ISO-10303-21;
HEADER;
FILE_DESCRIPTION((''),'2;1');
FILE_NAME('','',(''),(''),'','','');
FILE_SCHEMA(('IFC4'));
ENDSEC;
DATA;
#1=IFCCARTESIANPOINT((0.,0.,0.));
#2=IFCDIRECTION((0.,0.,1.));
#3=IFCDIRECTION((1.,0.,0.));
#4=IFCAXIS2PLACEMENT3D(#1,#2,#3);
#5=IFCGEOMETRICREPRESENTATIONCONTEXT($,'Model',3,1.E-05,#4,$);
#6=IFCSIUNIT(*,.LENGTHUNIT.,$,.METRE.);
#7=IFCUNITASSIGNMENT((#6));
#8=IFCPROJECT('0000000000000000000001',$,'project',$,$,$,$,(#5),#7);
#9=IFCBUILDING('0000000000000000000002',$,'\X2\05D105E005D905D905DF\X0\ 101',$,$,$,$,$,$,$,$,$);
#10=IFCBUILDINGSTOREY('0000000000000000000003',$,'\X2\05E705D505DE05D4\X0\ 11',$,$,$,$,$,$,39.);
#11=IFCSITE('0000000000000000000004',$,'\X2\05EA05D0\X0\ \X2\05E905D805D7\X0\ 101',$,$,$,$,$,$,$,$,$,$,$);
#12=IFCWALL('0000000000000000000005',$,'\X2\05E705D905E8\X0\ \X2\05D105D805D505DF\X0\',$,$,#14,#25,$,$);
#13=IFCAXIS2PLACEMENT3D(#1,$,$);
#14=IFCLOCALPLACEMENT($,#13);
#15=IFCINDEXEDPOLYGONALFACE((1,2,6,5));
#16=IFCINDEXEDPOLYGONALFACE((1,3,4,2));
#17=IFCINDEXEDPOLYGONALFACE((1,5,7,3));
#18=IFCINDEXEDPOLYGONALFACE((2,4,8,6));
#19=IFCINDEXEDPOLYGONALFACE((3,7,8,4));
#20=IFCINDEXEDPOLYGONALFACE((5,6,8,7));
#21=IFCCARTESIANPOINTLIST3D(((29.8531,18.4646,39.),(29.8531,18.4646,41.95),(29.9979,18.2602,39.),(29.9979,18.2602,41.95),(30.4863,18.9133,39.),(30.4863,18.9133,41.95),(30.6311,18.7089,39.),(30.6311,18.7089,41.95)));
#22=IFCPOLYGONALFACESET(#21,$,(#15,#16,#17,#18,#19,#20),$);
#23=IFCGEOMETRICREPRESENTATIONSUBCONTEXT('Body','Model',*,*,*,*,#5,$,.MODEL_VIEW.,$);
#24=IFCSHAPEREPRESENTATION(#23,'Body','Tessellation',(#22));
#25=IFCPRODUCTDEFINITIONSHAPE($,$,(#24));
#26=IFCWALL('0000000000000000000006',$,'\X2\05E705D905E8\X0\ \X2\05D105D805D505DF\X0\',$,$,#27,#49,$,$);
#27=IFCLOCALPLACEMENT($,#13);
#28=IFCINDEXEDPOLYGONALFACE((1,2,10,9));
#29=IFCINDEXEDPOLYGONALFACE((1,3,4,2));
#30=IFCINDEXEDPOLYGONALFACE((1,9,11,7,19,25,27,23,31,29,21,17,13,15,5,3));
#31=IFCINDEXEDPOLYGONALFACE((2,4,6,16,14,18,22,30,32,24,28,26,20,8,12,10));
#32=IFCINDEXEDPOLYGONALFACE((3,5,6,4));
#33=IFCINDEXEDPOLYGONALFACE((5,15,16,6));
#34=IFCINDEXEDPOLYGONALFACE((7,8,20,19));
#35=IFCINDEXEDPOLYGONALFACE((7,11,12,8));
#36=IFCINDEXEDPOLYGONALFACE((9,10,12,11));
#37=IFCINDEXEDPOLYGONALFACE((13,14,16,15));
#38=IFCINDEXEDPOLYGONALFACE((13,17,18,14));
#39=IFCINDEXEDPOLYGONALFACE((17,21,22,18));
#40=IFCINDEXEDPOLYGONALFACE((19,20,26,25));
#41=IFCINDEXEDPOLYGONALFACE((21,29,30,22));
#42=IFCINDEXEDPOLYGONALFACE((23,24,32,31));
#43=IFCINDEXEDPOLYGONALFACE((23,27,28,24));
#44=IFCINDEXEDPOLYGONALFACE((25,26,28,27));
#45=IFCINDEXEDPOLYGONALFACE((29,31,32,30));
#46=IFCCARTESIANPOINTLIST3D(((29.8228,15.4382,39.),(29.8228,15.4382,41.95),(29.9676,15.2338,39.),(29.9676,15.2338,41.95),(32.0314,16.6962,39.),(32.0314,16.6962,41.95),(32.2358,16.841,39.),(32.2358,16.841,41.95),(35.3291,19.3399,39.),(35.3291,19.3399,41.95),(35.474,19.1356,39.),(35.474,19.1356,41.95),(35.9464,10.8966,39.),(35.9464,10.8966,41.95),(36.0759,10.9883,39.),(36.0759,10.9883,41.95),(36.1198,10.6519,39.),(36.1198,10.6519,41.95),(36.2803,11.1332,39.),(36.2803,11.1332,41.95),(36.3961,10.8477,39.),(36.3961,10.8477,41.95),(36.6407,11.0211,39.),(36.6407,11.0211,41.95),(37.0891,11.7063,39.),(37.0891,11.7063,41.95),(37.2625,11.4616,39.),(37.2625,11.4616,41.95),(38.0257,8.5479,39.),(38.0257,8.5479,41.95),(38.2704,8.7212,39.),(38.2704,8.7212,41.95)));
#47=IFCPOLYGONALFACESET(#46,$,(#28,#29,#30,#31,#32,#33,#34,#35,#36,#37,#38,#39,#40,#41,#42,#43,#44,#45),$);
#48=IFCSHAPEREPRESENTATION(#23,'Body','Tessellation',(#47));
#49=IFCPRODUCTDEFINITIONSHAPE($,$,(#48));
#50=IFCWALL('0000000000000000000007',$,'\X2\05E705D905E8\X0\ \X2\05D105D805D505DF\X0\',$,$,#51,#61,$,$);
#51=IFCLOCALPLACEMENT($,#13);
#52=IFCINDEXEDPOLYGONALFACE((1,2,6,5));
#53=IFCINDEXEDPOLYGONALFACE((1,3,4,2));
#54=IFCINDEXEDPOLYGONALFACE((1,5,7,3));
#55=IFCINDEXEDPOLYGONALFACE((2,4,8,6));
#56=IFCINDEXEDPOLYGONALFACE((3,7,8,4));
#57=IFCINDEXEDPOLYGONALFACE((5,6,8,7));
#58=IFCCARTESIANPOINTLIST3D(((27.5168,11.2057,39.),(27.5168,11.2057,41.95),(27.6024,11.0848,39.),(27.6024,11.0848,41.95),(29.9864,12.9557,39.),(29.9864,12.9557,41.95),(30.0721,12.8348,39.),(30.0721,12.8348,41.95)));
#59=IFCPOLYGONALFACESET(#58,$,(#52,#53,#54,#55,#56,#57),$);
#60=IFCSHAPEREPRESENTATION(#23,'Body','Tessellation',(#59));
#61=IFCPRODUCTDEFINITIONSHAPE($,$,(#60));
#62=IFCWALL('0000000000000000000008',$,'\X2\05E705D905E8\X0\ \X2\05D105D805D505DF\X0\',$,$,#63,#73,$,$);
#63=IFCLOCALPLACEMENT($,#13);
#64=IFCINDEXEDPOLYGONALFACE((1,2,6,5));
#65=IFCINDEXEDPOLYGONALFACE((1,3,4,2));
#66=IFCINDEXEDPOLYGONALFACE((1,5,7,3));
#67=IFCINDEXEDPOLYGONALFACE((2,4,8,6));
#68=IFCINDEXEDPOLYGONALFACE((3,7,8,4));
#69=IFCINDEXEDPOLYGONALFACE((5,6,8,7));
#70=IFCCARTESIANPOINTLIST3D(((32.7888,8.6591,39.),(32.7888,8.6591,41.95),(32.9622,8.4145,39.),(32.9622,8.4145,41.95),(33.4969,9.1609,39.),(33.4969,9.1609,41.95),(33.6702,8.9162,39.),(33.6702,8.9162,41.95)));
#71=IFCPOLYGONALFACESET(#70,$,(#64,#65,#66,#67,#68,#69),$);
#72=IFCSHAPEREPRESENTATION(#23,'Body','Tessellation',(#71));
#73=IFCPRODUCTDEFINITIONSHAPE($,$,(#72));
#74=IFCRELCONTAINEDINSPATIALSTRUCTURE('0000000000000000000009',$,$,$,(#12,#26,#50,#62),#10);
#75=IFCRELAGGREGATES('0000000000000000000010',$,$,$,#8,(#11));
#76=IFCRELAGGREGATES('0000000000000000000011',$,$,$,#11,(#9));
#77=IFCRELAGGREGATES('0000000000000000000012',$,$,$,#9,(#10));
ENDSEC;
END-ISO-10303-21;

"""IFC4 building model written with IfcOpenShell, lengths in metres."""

from ifc_helpers import new_model, si_unit, frame, origin_with_axes, context, subcontext, project, spatial, polyline, outline, extrude, element, save


model = new_model("IFC4")

# Units and contexts
model_context = context("Model", 3, precision=1e-05, world=origin_with_axes())
body_context = subcontext(model_context, "Body", "Model", "MODEL_VIEW")
ifc_project = project(units=[si_unit("LENGTHUNIT", "METRE")], contexts=[model_context])

# Site, building, storey
site = spatial("IfcSite", under=ifc_project, Name="תא שטח 101")
building = spatial("IfcBuilding", under=site, Name="בניין 101")
storey = spatial("IfcBuildingStorey", under=building, Name="קומה 11", Elevation=39.0)

# Walls
element("IfcWall", 1, inside=storey, Name="קיר בטון", context=body_context, shape_type="SweptSolid", body=[
    extrude(outline(polyline([(29.9979, 18.2602), (30.6311, 18.7089), (30.4863, 18.9133), (29.8531, 18.4646), (29.9979, 18.2602)])), frame((0.0, 0.0, 39.0)), (0.0, 0.0, 1.0), 2.95),
])
element("IfcWall", 2, inside=storey, Name="קיר בטון", context=body_context, shape_type="SweptSolid", body=[
    extrude(outline(polyline([(29.8228, 15.4382), (29.9676, 15.2338), (32.0314, 16.6962), (36.0759, 10.9883), (35.9464, 10.8966), (36.1198, 10.6519), (36.3961, 10.8477), (38.0257, 8.5479), (38.2704, 8.7212), (36.6407, 11.0211), (37.2625, 11.4616), (37.0891, 11.7063), (36.2803, 11.1332), (32.2358, 16.841), (35.474, 19.1356), (35.3291, 19.3399), (29.8228, 15.4382)])), frame((0.0, 0.0, 39.0)), (0.0, 0.0, 1.0), 2.95),
])
element("IfcWall", 3, inside=storey, Name="קיר בטון", context=body_context, shape_type="SweptSolid", body=[
    extrude(outline(polyline([(30.0721, 12.8348), (29.9864, 12.9557), (27.5168, 11.2057), (27.6024, 11.0848), (30.0721, 12.8348)])), frame((0.0, 0.0, 39.0)), (0.0, 0.0, 1.0), 2.95),
])
element("IfcWall", 4, inside=storey, Name="קיר בטון", context=body_context, shape_type="SweptSolid", body=[
    extrude(outline(polyline([(33.4969, 9.1609), (32.7888, 8.6591), (32.9622, 8.4145), (33.6702, 8.9162), (33.4969, 9.1609)])), frame((0.0, 0.0, 39.0)), (0.0, 0.0, 1.0), 2.95),
])

save(model, "model.ifc")
